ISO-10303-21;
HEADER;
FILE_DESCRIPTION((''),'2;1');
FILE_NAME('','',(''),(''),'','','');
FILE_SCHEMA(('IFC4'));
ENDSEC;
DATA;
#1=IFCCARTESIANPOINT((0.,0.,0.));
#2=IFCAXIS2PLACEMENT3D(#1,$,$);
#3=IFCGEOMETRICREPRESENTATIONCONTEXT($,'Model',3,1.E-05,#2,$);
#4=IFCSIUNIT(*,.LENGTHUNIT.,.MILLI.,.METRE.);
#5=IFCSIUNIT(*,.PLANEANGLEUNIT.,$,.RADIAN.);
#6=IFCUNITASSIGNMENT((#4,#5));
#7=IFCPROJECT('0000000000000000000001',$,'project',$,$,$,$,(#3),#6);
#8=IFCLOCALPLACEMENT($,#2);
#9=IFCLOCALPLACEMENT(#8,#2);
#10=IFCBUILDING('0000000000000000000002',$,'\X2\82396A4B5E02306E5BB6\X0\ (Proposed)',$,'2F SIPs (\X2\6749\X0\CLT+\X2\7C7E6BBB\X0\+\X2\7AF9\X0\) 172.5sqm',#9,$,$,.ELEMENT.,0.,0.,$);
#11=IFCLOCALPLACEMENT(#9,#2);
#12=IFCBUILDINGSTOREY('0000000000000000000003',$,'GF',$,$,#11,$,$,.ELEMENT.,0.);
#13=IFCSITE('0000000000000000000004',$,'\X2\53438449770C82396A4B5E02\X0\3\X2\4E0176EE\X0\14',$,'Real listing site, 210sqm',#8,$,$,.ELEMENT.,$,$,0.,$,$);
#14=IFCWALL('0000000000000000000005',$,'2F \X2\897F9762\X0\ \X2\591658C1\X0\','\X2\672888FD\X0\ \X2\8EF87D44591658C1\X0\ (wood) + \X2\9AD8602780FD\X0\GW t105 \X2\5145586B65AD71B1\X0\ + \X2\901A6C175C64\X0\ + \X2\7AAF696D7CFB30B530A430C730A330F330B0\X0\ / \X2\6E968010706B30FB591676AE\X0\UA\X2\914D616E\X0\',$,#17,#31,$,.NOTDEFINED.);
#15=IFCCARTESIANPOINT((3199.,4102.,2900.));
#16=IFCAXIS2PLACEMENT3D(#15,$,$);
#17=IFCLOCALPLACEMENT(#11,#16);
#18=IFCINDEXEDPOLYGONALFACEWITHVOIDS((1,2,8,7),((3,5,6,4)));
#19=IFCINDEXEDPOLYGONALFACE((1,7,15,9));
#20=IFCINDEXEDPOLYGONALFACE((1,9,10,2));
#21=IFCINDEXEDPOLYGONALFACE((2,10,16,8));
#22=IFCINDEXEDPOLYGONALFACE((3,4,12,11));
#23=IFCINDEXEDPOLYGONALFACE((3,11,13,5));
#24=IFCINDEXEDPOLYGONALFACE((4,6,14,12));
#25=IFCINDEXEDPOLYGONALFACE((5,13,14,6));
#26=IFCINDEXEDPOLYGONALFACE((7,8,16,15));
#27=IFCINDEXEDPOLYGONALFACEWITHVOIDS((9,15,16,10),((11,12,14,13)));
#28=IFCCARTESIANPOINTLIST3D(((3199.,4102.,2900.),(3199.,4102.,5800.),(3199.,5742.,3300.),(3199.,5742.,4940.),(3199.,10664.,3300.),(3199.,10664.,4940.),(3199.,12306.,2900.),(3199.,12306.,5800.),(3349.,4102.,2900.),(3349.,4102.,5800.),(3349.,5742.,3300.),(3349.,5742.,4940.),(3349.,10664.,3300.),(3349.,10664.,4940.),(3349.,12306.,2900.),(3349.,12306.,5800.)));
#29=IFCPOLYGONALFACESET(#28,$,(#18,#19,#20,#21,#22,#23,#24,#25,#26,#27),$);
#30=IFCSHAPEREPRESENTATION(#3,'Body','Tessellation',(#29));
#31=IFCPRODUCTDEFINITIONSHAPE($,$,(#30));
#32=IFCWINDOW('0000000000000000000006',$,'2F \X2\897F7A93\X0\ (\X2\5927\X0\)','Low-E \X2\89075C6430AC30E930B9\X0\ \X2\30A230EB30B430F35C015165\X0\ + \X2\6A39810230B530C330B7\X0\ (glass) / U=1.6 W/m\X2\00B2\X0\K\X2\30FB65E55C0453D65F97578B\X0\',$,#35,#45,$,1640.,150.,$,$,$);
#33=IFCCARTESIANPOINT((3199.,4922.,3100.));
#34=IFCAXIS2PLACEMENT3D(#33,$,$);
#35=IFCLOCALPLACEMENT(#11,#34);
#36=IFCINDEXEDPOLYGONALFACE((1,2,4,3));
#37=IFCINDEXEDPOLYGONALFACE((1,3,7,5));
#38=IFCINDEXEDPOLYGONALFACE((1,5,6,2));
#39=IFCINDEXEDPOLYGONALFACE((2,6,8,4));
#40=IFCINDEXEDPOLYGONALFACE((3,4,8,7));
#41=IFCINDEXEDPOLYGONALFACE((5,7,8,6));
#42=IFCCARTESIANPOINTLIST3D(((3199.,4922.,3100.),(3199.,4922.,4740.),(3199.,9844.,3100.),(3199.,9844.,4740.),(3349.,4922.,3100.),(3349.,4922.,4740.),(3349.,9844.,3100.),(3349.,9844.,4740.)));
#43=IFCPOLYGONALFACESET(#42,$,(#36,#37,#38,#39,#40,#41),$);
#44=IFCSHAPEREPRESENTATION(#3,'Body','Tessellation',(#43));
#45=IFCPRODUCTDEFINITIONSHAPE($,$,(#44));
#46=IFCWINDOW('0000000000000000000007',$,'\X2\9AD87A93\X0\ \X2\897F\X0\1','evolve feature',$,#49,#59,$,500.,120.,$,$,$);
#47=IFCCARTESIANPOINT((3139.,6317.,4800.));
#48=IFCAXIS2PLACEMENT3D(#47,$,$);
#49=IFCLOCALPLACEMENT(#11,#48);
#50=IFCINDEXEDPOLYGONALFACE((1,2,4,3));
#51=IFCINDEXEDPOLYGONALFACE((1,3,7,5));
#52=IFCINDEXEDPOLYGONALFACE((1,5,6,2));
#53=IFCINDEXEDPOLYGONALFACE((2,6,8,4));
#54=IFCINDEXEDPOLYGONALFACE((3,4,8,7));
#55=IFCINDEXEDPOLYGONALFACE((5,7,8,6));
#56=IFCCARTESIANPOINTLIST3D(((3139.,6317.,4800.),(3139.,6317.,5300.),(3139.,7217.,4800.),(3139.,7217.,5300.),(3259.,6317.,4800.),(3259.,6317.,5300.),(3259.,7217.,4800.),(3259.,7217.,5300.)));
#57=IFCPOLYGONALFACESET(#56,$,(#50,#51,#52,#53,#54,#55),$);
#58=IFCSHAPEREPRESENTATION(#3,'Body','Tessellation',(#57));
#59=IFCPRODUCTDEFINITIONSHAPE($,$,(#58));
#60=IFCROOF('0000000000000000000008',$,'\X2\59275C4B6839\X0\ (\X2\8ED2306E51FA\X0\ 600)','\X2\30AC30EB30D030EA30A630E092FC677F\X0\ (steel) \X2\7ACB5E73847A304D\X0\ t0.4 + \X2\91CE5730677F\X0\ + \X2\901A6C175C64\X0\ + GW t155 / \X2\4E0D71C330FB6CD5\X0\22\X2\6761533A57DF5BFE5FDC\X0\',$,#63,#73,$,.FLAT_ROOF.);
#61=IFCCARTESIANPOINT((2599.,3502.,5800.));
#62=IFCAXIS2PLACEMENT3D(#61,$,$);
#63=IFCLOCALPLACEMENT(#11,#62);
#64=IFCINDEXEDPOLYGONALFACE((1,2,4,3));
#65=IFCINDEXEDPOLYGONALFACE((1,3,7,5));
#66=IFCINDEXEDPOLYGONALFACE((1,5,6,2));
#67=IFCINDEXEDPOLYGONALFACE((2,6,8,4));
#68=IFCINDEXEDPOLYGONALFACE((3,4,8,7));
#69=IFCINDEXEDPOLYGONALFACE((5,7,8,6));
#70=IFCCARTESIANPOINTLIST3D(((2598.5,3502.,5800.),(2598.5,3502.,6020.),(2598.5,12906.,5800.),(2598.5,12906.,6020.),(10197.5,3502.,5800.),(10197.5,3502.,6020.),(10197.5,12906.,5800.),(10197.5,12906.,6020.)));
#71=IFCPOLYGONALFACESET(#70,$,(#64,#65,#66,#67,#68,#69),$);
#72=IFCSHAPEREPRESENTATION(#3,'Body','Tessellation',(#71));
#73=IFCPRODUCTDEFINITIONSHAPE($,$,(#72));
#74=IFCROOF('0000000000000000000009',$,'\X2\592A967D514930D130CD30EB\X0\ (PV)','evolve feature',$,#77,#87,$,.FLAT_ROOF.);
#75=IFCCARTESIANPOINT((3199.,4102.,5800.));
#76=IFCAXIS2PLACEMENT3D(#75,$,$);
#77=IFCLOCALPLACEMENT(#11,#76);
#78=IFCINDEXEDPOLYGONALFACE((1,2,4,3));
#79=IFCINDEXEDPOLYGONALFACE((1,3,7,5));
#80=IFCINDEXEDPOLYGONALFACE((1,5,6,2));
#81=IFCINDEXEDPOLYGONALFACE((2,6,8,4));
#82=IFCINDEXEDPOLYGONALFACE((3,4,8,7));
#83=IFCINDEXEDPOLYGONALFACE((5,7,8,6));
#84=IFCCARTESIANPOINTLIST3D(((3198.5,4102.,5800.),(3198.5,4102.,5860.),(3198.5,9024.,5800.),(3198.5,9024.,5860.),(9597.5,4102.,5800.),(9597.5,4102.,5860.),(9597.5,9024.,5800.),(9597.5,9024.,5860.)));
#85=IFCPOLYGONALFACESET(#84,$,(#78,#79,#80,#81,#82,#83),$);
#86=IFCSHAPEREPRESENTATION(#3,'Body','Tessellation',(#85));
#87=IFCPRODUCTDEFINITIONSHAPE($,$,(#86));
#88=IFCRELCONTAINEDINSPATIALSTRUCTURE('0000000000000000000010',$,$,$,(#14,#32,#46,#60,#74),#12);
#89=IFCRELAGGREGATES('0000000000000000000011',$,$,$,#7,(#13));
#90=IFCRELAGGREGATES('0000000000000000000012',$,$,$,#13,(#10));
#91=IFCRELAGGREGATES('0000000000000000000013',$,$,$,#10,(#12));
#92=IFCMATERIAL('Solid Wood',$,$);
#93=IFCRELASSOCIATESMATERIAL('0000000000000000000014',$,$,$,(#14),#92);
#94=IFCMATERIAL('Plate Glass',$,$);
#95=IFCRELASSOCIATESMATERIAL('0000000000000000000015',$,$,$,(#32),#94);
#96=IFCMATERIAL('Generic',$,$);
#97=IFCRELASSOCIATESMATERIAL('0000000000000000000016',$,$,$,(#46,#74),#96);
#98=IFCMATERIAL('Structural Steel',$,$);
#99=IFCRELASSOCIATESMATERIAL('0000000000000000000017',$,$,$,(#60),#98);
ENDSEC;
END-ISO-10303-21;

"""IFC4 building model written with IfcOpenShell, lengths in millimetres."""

from ifc_helpers import new_model, si_unit, frame, frame_2d, origin, place, context, project, spatial, rectangle, extrude, material, element, fill, save


model = new_model("IFC4")

# Units and contexts
model_context = context("Model", 3, precision=1e-05, world=origin())
ifc_project = project(units=[si_unit("LENGTHUNIT", "METRE", prefix="MILLI"), si_unit("PLANEANGLEUNIT", "RADIAN")], contexts=[model_context])

# Site, building, storey
site_placement = place(None, origin())
site = spatial("IfcSite", under=ifc_project, at=site_placement, Name="千葉県船橋市3丁目14", ObjectType="Real listing site, 210sqm", CompositionType="ELEMENT", RefElevation=0.0)
building_placement = place(site_placement, origin())
building = spatial("IfcBuilding", under=site, at=building_placement, Name="船橋市の家 (Proposed)", ObjectType="2F SIPs (杉CLT+籾殻+竹) 172.5sqm", CompositionType="ELEMENT", ElevationOfRefHeight=0.0, ElevationOfTerrain=0.0)
storey_placement = place(building_placement, origin())
storey = spatial("IfcBuildingStorey", under=building, at=storey_placement, Name="GF", CompositionType="ELEMENT", Elevation=0.0)

# Shared definitions
ifc_material_1 = material(Name="Solid Wood")
ifc_material_2 = material(Name="Generic")

# Shared definitions
ifc_material_3 = material(Name="Plate Glass")

# Wall, openings, windows
wall_1_placement = place(storey_placement, frame((3199.0, 4102.0, 2900.0)))
wall_1 = element("IfcWall", 1, at=wall_1_placement, inside=storey, material=ifc_material_1, Name="2F 西面 外壁", Description="木製 軸組外壁 (wood) + 高性能GW t105 充填断熱 + 通気層 + 窯業系サイディング / 準耐火・外皮UA配慮", PredefinedType="NOTDEFINED", context=model_context, shape_type="SweptSolid", body=[
    extrude(rectangle(XDim=150.0, YDim=8204.0, at=frame_2d((75.0, 4102.0))), frame((3199.0, 4102.0, 2900.0)), (0.0, 0.0, 1.0), 2900.0),
])
opening_1_placement = place(storey_placement, frame((3199.0, 4922.0, 3100.0)))
opening_1 = element("IfcOpeningElement", 2, at=opening_1_placement, cuts=wall_1, PredefinedType="NOTDEFINED", context=model_context, shape_type="SweptSolid", body=[
    extrude(rectangle(XDim=150.0, YDim=4922.0, at=frame_2d((75.0, 2461.0))), frame((3199.0, 4922.0, 3100.0)), (0.0, 0.0, 1.0), 1640.0),
])
opening_2_placement = place(storey_placement, frame((3139.0, 6317.0, 4800.0)))
opening_2 = element("IfcOpeningElement", 3, at=opening_2_placement, cuts=wall_1, PredefinedType="NOTDEFINED", context=model_context, shape_type="SweptSolid", body=[
    extrude(rectangle(XDim=120.0, YDim=900.0, at=frame_2d((60.0, 450.0))), frame((3139.0, 6317.0, 4800.0)), (0.0, 0.0, 1.0), 500.0),
])
window_1_placement = place(storey_placement, frame((3199.0, 4922.0, 3100.0)))
window_1 = element("IfcWindow", 4, at=window_1_placement, inside=storey, material=ifc_material_3, Name="2F 西窓 (大)", Description="Low-E 複層ガラス アルゴン封入 + 樹脂サッシ (glass) / U=1.6 W/m²K・日射取得型", OverallHeight=1640.0, OverallWidth=150.0, context=model_context, shape_type="SweptSolid", body=[
    extrude(rectangle(XDim=150.0, YDim=4922.0, at=frame_2d((75.0, 2461.0))), frame((3199.0, 4922.0, 3100.0)), (0.0, 0.0, 1.0), 1640.0),
])
fill(opening_1, window_1)
window_2_placement = place(storey_placement, frame((3139.0, 6317.0, 4800.0)))
window_2 = element("IfcWindow", 5, at=window_2_placement, inside=storey, material=ifc_material_2, Name="高窓 西1", Description="evolve feature", OverallHeight=500.0, OverallWidth=120.0, context=model_context, shape_type="SweptSolid", body=[
    extrude(rectangle(XDim=120.0, YDim=900.0, at=frame_2d((60.0, 450.0))), frame((3139.0, 6317.0, 4800.0)), (0.0, 0.0, 1.0), 500.0),
])
fill(opening_2, window_2)

# Roofs
ifc_material_4 = material(Name="Structural Steel")
roof_1_placement = place(storey_placement, frame((2599.0, 3502.0, 5800.0)))
element("IfcRoof", 6, at=roof_1_placement, inside=storey, material=ifc_material_4, Name="大屋根 (軒の出 600)", Description="ガルバリウム鋼板 (steel) 立平葺き t0.4 + 野地板 + 通気層 + GW t155 / 不燃・法22条区域対応", PredefinedType="FLAT_ROOF", context=model_context, shape_type="SweptSolid", body=[
    extrude(rectangle(XDim=7599.0, YDim=9404.0, at=frame_2d((3799.0, 4702.0))), frame((2599.0, 3502.0, 5800.0)), (0.0, 0.0, 1.0), 220.0),
])
roof_2_placement = place(storey_placement, frame((3199.0, 4102.0, 5800.0)))
element("IfcRoof", 7, at=roof_2_placement, inside=storey, material=ifc_material_2, Name="太陽光パネル (PV)", Description="evolve feature", PredefinedType="FLAT_ROOF", context=model_context, shape_type="SweptSolid", body=[
    extrude(rectangle(XDim=6399.0, YDim=4922.0, at=frame_2d((3199.0, 2461.0))), frame((3199.0, 4102.0, 5800.0)), (0.0, 0.0, 1.0), 60.0),
])

save(model, "model.ifc")
